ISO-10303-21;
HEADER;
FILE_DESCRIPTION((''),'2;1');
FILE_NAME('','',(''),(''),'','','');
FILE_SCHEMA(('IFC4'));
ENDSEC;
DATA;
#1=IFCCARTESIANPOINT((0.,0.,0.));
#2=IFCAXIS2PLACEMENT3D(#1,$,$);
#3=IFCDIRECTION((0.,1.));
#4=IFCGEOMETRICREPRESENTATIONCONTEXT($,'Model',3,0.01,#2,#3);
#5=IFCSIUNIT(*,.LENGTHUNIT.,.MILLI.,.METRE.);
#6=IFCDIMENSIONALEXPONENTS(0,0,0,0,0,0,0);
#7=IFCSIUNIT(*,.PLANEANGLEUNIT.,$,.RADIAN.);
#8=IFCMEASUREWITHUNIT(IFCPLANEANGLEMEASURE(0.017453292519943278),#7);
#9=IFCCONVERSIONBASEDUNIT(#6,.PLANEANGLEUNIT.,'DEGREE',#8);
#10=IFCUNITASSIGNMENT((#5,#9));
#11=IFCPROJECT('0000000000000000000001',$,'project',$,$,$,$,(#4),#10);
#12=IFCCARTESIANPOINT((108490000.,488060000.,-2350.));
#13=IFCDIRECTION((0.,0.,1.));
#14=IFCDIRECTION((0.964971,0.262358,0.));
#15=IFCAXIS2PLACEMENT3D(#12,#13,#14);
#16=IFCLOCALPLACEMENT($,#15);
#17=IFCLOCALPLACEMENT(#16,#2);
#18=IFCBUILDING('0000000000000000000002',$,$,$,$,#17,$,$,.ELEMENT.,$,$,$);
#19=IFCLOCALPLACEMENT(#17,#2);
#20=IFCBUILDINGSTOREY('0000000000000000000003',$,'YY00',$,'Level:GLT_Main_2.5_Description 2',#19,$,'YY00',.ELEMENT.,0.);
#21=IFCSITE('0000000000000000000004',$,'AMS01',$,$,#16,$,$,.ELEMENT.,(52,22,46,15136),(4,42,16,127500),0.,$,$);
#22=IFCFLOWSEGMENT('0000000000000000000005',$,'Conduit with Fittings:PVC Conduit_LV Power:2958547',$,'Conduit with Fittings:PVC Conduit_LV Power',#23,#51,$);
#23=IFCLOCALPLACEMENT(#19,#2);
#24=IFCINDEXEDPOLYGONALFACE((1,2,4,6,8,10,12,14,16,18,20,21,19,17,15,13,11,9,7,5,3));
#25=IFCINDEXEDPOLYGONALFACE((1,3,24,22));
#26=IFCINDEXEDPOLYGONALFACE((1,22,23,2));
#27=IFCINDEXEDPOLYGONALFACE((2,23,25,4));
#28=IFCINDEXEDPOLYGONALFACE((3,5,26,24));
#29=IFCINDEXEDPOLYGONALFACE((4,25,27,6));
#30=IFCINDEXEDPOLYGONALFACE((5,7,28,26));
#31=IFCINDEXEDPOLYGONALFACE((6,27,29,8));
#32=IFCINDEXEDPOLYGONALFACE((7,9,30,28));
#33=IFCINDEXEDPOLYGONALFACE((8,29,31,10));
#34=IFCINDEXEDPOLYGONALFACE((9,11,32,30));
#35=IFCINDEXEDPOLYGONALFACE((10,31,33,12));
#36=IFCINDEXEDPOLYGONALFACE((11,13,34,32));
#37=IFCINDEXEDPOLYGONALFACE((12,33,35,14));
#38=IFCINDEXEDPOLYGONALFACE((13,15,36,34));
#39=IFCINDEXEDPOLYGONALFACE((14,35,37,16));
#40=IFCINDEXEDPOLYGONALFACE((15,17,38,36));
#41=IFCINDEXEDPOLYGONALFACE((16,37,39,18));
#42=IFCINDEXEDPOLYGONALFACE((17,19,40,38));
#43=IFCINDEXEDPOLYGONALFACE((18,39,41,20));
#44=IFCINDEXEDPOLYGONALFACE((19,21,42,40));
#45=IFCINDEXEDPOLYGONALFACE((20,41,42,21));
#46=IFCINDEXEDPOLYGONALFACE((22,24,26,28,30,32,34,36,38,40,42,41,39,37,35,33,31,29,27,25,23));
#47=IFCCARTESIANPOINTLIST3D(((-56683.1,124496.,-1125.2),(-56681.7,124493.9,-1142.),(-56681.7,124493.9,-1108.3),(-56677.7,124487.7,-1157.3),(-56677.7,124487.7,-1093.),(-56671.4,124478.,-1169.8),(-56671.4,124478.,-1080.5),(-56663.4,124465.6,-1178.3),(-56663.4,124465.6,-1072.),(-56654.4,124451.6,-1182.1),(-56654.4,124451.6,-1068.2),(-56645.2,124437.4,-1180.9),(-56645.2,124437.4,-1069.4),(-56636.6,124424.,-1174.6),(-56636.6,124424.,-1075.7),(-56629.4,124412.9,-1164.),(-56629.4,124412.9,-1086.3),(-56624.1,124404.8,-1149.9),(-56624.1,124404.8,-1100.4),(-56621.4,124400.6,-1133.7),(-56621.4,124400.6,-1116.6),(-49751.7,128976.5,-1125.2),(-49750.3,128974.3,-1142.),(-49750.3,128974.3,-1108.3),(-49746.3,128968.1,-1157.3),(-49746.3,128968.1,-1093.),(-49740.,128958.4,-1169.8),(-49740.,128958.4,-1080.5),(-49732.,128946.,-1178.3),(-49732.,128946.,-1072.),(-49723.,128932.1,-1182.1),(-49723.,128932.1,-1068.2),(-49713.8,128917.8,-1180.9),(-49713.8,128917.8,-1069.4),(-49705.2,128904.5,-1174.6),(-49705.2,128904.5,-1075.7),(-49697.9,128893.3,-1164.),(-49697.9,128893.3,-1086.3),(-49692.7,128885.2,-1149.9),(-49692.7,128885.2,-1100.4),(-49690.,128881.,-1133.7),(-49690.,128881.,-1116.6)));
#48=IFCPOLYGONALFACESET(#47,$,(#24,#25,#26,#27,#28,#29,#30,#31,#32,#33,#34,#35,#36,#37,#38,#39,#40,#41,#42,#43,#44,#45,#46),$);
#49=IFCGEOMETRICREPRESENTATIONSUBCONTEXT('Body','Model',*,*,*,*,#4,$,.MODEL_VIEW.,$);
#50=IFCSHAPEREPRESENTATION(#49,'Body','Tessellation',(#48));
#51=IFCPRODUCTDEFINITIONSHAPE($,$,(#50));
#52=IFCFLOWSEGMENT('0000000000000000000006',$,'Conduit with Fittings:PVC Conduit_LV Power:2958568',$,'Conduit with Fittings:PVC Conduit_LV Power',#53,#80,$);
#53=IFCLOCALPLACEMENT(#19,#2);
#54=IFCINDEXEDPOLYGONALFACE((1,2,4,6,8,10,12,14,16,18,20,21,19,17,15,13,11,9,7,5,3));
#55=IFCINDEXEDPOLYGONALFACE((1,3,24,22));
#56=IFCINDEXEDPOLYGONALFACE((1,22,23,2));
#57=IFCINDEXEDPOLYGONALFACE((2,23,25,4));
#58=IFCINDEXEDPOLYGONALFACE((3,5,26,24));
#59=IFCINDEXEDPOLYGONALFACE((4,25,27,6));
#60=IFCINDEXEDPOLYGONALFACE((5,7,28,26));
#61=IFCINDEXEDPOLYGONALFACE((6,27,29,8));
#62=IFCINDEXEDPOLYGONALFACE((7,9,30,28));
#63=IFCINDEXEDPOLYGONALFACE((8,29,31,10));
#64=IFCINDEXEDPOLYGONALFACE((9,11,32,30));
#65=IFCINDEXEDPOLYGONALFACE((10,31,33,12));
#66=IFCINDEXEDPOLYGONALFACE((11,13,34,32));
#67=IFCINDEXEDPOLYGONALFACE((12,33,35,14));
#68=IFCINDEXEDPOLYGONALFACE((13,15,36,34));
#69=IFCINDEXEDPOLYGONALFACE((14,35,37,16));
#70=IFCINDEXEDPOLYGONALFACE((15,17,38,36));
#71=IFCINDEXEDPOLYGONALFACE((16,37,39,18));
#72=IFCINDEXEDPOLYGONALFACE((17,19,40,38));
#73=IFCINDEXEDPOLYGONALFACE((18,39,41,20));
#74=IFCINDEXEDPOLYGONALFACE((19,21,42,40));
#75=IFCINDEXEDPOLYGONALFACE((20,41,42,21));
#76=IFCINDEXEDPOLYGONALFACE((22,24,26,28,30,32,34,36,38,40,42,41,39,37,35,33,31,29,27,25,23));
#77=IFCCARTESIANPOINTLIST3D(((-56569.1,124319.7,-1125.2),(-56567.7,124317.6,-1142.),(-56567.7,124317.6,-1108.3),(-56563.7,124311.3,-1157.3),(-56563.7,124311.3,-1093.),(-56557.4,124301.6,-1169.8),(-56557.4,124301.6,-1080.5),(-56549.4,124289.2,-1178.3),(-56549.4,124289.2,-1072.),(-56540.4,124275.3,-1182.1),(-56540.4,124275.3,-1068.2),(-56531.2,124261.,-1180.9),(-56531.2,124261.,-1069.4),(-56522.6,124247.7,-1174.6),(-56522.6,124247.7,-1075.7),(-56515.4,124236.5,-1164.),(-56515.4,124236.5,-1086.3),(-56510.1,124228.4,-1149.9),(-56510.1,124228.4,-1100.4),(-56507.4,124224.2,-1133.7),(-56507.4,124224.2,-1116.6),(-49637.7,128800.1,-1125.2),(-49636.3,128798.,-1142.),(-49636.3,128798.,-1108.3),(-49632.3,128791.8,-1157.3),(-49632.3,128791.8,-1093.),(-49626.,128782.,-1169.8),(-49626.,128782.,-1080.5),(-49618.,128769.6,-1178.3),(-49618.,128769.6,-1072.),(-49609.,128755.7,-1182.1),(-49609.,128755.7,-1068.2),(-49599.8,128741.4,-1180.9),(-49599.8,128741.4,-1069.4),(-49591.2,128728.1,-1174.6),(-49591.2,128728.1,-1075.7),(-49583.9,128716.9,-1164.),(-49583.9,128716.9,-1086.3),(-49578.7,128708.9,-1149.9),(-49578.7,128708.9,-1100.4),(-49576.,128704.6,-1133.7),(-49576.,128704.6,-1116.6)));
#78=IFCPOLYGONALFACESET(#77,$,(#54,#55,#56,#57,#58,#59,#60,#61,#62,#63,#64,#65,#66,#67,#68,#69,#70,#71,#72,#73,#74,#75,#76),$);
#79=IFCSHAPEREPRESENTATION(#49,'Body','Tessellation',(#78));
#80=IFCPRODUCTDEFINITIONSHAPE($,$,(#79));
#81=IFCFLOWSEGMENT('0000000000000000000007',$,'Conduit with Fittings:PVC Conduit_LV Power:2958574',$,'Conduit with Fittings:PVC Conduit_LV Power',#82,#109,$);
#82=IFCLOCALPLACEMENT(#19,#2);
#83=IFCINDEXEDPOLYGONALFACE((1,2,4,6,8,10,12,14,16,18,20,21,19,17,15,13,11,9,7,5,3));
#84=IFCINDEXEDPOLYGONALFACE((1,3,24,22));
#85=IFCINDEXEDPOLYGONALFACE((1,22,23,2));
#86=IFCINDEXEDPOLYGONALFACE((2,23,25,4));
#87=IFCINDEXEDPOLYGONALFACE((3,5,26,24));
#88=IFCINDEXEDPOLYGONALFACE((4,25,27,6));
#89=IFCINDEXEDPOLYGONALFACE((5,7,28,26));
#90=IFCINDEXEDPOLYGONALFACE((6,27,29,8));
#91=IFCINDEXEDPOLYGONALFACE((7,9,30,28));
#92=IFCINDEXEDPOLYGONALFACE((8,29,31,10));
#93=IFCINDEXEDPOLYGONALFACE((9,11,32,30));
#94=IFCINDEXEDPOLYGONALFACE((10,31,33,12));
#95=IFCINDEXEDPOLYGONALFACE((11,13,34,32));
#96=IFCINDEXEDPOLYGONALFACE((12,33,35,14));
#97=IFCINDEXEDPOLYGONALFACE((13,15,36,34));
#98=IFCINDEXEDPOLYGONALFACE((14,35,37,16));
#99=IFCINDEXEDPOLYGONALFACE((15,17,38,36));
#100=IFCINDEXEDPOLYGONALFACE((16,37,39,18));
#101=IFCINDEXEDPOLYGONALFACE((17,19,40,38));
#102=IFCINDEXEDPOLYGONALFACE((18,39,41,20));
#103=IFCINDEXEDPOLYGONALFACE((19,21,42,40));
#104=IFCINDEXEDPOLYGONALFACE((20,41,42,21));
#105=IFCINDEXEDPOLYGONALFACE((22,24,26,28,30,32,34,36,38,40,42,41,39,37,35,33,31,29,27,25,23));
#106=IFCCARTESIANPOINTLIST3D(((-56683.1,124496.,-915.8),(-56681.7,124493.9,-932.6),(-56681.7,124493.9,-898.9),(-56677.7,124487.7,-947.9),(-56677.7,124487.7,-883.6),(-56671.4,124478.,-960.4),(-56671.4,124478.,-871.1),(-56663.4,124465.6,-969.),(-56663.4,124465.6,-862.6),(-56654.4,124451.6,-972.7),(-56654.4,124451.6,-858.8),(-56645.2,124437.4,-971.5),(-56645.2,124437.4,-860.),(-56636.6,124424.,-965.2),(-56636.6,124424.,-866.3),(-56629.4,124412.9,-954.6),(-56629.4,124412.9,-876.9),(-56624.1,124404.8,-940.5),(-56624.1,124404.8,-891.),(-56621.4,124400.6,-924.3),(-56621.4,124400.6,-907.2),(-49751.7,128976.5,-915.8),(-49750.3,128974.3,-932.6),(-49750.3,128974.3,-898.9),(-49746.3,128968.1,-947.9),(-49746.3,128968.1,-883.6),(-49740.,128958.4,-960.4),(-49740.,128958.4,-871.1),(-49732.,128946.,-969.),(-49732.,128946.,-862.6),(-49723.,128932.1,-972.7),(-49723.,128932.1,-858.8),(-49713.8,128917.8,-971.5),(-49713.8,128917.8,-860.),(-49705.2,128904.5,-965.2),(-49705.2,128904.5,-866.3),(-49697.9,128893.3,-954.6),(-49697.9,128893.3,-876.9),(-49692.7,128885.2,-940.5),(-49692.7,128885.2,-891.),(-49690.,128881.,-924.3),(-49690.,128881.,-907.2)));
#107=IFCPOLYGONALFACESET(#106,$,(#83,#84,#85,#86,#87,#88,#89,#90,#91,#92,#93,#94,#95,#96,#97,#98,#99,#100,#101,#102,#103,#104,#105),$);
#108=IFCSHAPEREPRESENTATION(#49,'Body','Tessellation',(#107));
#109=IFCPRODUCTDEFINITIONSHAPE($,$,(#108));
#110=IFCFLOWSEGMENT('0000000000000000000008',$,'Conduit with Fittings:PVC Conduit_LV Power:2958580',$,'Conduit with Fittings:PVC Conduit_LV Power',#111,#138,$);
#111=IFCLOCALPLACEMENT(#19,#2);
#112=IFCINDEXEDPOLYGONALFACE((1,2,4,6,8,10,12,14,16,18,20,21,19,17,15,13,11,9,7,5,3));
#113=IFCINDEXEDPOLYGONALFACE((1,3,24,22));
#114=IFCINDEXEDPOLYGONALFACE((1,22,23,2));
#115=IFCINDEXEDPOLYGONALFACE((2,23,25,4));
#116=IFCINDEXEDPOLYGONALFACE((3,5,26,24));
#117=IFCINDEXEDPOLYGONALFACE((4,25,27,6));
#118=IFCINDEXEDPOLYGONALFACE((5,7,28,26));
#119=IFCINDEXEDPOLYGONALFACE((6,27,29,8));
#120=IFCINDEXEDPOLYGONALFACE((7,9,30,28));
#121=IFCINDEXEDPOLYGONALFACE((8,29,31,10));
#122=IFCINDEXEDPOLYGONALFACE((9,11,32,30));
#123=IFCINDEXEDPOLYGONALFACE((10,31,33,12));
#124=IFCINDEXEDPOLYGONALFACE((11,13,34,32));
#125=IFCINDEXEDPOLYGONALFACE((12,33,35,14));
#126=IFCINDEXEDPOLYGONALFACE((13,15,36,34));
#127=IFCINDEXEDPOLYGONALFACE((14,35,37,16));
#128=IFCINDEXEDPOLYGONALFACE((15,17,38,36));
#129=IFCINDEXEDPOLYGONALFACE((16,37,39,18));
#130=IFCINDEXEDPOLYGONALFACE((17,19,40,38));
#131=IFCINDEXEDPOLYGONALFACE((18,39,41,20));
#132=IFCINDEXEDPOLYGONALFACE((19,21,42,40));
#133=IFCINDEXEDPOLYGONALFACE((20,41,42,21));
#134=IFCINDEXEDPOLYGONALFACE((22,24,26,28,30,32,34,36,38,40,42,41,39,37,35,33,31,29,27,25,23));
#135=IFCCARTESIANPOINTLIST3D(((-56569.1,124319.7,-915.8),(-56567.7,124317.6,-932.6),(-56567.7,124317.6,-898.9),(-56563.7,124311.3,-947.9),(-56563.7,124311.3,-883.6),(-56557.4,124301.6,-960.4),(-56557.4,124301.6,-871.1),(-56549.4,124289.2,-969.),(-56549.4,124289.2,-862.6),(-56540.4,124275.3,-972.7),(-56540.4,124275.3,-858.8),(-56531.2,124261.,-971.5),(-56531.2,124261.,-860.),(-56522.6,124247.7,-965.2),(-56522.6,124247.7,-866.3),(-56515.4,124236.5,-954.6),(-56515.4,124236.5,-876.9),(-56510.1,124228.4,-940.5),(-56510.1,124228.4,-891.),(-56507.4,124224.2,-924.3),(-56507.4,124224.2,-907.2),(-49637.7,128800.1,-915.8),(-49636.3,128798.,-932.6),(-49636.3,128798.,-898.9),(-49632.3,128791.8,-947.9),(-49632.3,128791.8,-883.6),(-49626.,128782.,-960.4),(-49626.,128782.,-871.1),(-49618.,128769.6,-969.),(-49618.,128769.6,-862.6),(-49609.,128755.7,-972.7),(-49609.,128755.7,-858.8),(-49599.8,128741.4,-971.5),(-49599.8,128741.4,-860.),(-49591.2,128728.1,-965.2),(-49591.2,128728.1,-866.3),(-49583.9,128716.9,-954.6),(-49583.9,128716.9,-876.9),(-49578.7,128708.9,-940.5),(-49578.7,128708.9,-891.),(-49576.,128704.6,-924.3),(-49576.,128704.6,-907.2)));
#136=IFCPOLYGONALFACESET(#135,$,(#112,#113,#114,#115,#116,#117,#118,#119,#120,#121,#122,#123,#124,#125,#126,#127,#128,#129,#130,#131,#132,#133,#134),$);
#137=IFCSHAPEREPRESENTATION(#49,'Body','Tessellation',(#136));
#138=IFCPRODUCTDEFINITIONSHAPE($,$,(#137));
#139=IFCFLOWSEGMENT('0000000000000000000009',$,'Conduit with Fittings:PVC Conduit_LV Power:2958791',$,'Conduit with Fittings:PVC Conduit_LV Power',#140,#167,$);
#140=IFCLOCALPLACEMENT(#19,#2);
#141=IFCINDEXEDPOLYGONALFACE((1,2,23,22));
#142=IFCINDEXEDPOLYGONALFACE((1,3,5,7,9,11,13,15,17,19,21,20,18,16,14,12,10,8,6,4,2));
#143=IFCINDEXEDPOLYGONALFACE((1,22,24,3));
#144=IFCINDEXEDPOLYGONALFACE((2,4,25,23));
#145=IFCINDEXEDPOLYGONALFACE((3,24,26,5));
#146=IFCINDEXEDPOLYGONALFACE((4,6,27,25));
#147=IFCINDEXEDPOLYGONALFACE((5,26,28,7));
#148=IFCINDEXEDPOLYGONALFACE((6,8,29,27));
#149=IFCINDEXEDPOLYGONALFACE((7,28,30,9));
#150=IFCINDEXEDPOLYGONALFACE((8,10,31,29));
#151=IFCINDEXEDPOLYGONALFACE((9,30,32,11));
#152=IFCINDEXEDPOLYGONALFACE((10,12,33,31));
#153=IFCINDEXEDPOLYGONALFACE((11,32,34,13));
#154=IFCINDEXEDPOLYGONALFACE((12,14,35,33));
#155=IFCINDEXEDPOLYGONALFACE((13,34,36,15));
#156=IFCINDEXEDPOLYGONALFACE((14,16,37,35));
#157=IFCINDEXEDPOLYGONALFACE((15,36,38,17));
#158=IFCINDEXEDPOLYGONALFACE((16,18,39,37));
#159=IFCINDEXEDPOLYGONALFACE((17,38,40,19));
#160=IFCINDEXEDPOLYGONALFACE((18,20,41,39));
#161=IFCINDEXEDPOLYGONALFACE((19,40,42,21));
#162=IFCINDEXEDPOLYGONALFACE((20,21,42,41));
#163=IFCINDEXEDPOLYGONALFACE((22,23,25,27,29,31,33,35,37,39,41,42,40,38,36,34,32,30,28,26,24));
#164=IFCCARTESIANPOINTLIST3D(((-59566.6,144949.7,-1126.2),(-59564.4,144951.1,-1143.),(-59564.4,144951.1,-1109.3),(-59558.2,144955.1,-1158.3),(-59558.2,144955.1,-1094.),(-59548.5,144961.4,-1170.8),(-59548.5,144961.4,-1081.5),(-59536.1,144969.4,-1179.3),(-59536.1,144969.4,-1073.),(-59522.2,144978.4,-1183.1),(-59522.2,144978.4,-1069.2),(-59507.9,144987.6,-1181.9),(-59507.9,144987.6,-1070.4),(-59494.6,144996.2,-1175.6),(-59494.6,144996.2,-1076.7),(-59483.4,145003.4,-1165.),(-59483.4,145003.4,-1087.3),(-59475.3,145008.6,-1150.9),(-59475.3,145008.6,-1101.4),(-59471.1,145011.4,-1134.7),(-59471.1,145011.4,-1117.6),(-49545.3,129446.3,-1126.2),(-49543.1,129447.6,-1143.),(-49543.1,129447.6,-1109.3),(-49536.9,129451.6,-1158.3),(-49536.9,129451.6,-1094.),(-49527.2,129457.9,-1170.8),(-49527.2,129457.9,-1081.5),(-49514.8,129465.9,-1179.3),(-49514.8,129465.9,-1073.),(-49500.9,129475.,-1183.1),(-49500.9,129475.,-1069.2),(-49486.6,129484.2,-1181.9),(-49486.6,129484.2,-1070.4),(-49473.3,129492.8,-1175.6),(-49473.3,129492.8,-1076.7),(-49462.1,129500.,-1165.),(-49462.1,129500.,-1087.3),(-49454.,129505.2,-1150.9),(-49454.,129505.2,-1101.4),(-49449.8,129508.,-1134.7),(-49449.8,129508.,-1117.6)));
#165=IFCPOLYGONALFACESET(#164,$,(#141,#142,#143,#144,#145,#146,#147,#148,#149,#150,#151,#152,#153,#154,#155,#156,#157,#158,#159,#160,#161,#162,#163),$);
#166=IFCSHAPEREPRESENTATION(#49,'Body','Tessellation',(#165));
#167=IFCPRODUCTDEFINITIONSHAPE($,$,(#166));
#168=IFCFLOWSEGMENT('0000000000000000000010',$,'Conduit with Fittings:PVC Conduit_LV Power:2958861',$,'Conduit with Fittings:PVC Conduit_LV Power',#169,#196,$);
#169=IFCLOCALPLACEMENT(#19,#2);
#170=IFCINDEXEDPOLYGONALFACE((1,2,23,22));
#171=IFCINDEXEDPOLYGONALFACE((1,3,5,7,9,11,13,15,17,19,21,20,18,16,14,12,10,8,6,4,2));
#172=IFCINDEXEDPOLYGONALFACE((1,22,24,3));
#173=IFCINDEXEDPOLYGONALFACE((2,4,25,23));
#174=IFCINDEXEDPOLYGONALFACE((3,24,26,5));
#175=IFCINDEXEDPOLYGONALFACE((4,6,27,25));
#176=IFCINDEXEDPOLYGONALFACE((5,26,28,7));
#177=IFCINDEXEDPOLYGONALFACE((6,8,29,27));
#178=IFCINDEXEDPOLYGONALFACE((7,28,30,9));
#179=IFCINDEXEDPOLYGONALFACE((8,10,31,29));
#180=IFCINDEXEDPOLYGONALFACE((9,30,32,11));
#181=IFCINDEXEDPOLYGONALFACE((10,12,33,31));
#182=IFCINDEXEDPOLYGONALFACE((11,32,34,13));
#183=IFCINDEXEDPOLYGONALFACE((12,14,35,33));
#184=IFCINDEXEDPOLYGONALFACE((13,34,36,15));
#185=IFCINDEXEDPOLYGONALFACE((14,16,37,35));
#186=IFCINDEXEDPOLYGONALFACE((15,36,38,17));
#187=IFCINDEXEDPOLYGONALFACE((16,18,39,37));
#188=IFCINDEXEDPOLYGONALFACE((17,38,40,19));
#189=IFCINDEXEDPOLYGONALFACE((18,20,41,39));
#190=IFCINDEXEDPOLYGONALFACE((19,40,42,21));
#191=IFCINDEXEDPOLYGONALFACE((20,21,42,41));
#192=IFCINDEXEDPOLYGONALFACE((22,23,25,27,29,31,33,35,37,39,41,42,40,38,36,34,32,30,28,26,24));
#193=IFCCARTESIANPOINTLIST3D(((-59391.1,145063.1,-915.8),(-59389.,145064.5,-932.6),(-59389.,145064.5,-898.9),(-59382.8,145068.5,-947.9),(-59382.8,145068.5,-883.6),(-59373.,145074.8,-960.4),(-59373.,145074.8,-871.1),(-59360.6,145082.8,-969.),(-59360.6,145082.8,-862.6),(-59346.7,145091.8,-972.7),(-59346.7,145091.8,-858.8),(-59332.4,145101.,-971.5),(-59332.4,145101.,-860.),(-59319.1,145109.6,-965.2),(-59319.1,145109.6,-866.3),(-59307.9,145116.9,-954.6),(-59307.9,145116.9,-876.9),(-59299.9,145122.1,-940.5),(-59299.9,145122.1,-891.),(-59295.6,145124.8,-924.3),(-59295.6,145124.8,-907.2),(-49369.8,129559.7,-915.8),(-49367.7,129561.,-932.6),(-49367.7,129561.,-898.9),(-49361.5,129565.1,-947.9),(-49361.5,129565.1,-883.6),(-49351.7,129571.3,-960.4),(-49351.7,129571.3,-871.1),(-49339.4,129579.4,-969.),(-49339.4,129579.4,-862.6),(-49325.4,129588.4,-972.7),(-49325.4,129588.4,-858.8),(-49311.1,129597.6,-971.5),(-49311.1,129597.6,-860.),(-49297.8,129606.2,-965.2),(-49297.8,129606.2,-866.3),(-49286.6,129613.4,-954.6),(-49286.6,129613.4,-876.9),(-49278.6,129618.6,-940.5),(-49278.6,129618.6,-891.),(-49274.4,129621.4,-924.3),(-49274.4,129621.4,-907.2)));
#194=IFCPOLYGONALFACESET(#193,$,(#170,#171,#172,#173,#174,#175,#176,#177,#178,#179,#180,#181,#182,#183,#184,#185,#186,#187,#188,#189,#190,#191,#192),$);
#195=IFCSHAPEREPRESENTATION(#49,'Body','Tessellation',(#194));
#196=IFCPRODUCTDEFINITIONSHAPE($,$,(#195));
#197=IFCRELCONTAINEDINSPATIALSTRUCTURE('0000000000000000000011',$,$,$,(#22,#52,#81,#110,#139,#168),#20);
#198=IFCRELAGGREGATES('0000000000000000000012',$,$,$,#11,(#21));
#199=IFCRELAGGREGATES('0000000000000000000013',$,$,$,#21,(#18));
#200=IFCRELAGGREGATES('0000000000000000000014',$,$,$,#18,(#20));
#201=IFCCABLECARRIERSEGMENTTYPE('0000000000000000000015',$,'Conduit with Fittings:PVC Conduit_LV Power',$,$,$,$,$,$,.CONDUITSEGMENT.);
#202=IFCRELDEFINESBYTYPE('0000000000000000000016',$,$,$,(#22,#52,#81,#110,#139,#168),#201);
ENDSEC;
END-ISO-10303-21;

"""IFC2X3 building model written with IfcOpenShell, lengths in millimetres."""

from ifc_helpers import new_model, entity, si_unit, converted_unit, direction, frame, frame_2d, origin, origin_2d_with_axis, place, context, subcontext, project, spatial, circle, extrude, type_object, element, save


model = new_model("IFC2X3")

# Units and contexts
model_context = context("Model", 3, precision=0.01, world=origin(), true_north=direction((0.0, 1.0)))
body_context = subcontext(model_context, "Body", "Model", "MODEL_VIEW")
ifc_project = project(units=[si_unit("LENGTHUNIT", "METRE", prefix="MILLI"), converted_unit("PLANEANGLEUNIT", "DEGREE", entity("IfcPlaneAngleMeasure", 0.017453292519943278), si_unit("PLANEANGLEUNIT", "RADIAN"), dimensions=[0, 0, 0, 0, 0, 0, 0])], contexts=[model_context])

# Site, building, storey
site_placement = place(None, frame((108490000.0, 488060000.0, -2350.0), z_axis=(0.0, 0.0, 1.0), x_axis=(0.964971, 0.262358, 0.0)))
site = spatial("IfcSite", under=ifc_project, at=site_placement, Name="AMS01", CompositionType="ELEMENT", RefLatitude=(52, 22, 46, 15136), RefLongitude=(4, 42, 16, 127500), RefElevation=0.0)
building_placement = place(site_placement, origin())
building = spatial("IfcBuilding", under=site, at=building_placement, CompositionType="ELEMENT")
storey_placement = place(building_placement, origin())
storey = spatial("IfcBuildingStorey", under=building, at=storey_placement, Name="YY00", ObjectType="Level:GLT_Main_2.5_Description 2", LongName="YY00", CompositionType="ELEMENT", Elevation=0.0)

# Flow segments
cable_carrier_segment_type = type_object("IfcCableCarrierSegmentType", Name="Conduit with Fittings:PVC Conduit_LV Power", PredefinedType="CONDUITSEGMENT")
flow_segment_1_placement = place(storey_placement, origin())
element("IfcFlowSegment", 1, at=flow_segment_1_placement, inside=storey, type_object=cable_carrier_segment_type, Name="Conduit with Fittings:PVC Conduit_LV Power:2958547", ObjectType="Conduit with Fittings:PVC Conduit_LV Power", context=body_context, shape_type="SweptSolid", body=[
    extrude(circle(Radius=57.2, at=origin_2d_with_axis()), frame((-56652.1, 124448.0, -1125.2), z_axis=(0.839826, 0.542856, 0.0), x_axis=(-0.542856, 0.839826, 0.0)), (0.0, 0.0, 1.0), 8253.4),
])
flow_segment_2_placement = place(storey_placement, origin())
element("IfcFlowSegment", 2, at=flow_segment_2_placement, inside=storey, type_object=cable_carrier_segment_type, Name="Conduit with Fittings:PVC Conduit_LV Power:2958568", ObjectType="Conduit with Fittings:PVC Conduit_LV Power", context=body_context, shape_type="SweptSolid", body=[
    extrude(circle(Radius=57.2, at=origin_2d_with_axis()), frame((-56538.1, 124271.7, -1125.2), z_axis=(0.839826, 0.542856, 0.0), x_axis=(-0.542856, 0.839826, 0.0)), (0.0, 0.0, 1.0), 8253.4),
])
flow_segment_3_placement = place(storey_placement, origin())
element("IfcFlowSegment", 3, at=flow_segment_3_placement, inside=storey, type_object=cable_carrier_segment_type, Name="Conduit with Fittings:PVC Conduit_LV Power:2958574", ObjectType="Conduit with Fittings:PVC Conduit_LV Power", context=body_context, shape_type="SweptSolid", body=[
    extrude(circle(Radius=57.2, at=origin_2d_with_axis()), frame((-56652.1, 124448.0, -915.8), z_axis=(0.839826, 0.542856, 0.0), x_axis=(-0.542856, 0.839826, 0.0)), (0.0, 0.0, 1.0), 8253.4),
])
flow_segment_4_placement = place(storey_placement, origin())
element("IfcFlowSegment", 4, at=flow_segment_4_placement, inside=storey, type_object=cable_carrier_segment_type, Name="Conduit with Fittings:PVC Conduit_LV Power:2958580", ObjectType="Conduit with Fittings:PVC Conduit_LV Power", context=body_context, shape_type="SweptSolid", body=[
    extrude(circle(Radius=57.2, at=origin_2d_with_axis()), frame((-56538.1, 124271.7, -915.8), z_axis=(0.839826, 0.542856, 0.0), x_axis=(-0.542856, 0.839826, 0.0)), (0.0, 0.0, 1.0), 8253.4),
])
flow_segment_5_placement = place(storey_placement, origin())
element("IfcFlowSegment", 5, at=flow_segment_5_placement, inside=storey, type_object=cable_carrier_segment_type, Name="Conduit with Fittings:PVC Conduit_LV Power:2958791", ObjectType="Conduit with Fittings:PVC Conduit_LV Power", context=body_context, shape_type="SweptSolid", body=[
    extrude(circle(Radius=57.2, at=frame_2d((0.0, 0.0), x_axis=(1.0, 0.0))), frame((-49497.3, 129477.3, -1126.2), z_axis=(-0.542856, 0.839826, 0.0), x_axis=(-0.839826, -0.542856, 0.0)), (0.0, 0.0, 1.0), 18460.3),
])
flow_segment_6_placement = place(storey_placement, origin())
element("IfcFlowSegment", 6, at=flow_segment_6_placement, inside=storey, type_object=cable_carrier_segment_type, Name="Conduit with Fittings:PVC Conduit_LV Power:2958861", ObjectType="Conduit with Fittings:PVC Conduit_LV Power", context=body_context, shape_type="SweptSolid", body=[
    extrude(circle(Radius=57.2, at=frame_2d((0.0, 0.0), x_axis=(1.0, 0.0))), frame((-49321.8, 129590.7, -915.8), z_axis=(-0.542856, 0.839826, 0.0), x_axis=(-0.839826, -0.542856, 0.0)), (0.0, 0.0, 1.0), 18460.3),
])

save(model, "model.ifc")
